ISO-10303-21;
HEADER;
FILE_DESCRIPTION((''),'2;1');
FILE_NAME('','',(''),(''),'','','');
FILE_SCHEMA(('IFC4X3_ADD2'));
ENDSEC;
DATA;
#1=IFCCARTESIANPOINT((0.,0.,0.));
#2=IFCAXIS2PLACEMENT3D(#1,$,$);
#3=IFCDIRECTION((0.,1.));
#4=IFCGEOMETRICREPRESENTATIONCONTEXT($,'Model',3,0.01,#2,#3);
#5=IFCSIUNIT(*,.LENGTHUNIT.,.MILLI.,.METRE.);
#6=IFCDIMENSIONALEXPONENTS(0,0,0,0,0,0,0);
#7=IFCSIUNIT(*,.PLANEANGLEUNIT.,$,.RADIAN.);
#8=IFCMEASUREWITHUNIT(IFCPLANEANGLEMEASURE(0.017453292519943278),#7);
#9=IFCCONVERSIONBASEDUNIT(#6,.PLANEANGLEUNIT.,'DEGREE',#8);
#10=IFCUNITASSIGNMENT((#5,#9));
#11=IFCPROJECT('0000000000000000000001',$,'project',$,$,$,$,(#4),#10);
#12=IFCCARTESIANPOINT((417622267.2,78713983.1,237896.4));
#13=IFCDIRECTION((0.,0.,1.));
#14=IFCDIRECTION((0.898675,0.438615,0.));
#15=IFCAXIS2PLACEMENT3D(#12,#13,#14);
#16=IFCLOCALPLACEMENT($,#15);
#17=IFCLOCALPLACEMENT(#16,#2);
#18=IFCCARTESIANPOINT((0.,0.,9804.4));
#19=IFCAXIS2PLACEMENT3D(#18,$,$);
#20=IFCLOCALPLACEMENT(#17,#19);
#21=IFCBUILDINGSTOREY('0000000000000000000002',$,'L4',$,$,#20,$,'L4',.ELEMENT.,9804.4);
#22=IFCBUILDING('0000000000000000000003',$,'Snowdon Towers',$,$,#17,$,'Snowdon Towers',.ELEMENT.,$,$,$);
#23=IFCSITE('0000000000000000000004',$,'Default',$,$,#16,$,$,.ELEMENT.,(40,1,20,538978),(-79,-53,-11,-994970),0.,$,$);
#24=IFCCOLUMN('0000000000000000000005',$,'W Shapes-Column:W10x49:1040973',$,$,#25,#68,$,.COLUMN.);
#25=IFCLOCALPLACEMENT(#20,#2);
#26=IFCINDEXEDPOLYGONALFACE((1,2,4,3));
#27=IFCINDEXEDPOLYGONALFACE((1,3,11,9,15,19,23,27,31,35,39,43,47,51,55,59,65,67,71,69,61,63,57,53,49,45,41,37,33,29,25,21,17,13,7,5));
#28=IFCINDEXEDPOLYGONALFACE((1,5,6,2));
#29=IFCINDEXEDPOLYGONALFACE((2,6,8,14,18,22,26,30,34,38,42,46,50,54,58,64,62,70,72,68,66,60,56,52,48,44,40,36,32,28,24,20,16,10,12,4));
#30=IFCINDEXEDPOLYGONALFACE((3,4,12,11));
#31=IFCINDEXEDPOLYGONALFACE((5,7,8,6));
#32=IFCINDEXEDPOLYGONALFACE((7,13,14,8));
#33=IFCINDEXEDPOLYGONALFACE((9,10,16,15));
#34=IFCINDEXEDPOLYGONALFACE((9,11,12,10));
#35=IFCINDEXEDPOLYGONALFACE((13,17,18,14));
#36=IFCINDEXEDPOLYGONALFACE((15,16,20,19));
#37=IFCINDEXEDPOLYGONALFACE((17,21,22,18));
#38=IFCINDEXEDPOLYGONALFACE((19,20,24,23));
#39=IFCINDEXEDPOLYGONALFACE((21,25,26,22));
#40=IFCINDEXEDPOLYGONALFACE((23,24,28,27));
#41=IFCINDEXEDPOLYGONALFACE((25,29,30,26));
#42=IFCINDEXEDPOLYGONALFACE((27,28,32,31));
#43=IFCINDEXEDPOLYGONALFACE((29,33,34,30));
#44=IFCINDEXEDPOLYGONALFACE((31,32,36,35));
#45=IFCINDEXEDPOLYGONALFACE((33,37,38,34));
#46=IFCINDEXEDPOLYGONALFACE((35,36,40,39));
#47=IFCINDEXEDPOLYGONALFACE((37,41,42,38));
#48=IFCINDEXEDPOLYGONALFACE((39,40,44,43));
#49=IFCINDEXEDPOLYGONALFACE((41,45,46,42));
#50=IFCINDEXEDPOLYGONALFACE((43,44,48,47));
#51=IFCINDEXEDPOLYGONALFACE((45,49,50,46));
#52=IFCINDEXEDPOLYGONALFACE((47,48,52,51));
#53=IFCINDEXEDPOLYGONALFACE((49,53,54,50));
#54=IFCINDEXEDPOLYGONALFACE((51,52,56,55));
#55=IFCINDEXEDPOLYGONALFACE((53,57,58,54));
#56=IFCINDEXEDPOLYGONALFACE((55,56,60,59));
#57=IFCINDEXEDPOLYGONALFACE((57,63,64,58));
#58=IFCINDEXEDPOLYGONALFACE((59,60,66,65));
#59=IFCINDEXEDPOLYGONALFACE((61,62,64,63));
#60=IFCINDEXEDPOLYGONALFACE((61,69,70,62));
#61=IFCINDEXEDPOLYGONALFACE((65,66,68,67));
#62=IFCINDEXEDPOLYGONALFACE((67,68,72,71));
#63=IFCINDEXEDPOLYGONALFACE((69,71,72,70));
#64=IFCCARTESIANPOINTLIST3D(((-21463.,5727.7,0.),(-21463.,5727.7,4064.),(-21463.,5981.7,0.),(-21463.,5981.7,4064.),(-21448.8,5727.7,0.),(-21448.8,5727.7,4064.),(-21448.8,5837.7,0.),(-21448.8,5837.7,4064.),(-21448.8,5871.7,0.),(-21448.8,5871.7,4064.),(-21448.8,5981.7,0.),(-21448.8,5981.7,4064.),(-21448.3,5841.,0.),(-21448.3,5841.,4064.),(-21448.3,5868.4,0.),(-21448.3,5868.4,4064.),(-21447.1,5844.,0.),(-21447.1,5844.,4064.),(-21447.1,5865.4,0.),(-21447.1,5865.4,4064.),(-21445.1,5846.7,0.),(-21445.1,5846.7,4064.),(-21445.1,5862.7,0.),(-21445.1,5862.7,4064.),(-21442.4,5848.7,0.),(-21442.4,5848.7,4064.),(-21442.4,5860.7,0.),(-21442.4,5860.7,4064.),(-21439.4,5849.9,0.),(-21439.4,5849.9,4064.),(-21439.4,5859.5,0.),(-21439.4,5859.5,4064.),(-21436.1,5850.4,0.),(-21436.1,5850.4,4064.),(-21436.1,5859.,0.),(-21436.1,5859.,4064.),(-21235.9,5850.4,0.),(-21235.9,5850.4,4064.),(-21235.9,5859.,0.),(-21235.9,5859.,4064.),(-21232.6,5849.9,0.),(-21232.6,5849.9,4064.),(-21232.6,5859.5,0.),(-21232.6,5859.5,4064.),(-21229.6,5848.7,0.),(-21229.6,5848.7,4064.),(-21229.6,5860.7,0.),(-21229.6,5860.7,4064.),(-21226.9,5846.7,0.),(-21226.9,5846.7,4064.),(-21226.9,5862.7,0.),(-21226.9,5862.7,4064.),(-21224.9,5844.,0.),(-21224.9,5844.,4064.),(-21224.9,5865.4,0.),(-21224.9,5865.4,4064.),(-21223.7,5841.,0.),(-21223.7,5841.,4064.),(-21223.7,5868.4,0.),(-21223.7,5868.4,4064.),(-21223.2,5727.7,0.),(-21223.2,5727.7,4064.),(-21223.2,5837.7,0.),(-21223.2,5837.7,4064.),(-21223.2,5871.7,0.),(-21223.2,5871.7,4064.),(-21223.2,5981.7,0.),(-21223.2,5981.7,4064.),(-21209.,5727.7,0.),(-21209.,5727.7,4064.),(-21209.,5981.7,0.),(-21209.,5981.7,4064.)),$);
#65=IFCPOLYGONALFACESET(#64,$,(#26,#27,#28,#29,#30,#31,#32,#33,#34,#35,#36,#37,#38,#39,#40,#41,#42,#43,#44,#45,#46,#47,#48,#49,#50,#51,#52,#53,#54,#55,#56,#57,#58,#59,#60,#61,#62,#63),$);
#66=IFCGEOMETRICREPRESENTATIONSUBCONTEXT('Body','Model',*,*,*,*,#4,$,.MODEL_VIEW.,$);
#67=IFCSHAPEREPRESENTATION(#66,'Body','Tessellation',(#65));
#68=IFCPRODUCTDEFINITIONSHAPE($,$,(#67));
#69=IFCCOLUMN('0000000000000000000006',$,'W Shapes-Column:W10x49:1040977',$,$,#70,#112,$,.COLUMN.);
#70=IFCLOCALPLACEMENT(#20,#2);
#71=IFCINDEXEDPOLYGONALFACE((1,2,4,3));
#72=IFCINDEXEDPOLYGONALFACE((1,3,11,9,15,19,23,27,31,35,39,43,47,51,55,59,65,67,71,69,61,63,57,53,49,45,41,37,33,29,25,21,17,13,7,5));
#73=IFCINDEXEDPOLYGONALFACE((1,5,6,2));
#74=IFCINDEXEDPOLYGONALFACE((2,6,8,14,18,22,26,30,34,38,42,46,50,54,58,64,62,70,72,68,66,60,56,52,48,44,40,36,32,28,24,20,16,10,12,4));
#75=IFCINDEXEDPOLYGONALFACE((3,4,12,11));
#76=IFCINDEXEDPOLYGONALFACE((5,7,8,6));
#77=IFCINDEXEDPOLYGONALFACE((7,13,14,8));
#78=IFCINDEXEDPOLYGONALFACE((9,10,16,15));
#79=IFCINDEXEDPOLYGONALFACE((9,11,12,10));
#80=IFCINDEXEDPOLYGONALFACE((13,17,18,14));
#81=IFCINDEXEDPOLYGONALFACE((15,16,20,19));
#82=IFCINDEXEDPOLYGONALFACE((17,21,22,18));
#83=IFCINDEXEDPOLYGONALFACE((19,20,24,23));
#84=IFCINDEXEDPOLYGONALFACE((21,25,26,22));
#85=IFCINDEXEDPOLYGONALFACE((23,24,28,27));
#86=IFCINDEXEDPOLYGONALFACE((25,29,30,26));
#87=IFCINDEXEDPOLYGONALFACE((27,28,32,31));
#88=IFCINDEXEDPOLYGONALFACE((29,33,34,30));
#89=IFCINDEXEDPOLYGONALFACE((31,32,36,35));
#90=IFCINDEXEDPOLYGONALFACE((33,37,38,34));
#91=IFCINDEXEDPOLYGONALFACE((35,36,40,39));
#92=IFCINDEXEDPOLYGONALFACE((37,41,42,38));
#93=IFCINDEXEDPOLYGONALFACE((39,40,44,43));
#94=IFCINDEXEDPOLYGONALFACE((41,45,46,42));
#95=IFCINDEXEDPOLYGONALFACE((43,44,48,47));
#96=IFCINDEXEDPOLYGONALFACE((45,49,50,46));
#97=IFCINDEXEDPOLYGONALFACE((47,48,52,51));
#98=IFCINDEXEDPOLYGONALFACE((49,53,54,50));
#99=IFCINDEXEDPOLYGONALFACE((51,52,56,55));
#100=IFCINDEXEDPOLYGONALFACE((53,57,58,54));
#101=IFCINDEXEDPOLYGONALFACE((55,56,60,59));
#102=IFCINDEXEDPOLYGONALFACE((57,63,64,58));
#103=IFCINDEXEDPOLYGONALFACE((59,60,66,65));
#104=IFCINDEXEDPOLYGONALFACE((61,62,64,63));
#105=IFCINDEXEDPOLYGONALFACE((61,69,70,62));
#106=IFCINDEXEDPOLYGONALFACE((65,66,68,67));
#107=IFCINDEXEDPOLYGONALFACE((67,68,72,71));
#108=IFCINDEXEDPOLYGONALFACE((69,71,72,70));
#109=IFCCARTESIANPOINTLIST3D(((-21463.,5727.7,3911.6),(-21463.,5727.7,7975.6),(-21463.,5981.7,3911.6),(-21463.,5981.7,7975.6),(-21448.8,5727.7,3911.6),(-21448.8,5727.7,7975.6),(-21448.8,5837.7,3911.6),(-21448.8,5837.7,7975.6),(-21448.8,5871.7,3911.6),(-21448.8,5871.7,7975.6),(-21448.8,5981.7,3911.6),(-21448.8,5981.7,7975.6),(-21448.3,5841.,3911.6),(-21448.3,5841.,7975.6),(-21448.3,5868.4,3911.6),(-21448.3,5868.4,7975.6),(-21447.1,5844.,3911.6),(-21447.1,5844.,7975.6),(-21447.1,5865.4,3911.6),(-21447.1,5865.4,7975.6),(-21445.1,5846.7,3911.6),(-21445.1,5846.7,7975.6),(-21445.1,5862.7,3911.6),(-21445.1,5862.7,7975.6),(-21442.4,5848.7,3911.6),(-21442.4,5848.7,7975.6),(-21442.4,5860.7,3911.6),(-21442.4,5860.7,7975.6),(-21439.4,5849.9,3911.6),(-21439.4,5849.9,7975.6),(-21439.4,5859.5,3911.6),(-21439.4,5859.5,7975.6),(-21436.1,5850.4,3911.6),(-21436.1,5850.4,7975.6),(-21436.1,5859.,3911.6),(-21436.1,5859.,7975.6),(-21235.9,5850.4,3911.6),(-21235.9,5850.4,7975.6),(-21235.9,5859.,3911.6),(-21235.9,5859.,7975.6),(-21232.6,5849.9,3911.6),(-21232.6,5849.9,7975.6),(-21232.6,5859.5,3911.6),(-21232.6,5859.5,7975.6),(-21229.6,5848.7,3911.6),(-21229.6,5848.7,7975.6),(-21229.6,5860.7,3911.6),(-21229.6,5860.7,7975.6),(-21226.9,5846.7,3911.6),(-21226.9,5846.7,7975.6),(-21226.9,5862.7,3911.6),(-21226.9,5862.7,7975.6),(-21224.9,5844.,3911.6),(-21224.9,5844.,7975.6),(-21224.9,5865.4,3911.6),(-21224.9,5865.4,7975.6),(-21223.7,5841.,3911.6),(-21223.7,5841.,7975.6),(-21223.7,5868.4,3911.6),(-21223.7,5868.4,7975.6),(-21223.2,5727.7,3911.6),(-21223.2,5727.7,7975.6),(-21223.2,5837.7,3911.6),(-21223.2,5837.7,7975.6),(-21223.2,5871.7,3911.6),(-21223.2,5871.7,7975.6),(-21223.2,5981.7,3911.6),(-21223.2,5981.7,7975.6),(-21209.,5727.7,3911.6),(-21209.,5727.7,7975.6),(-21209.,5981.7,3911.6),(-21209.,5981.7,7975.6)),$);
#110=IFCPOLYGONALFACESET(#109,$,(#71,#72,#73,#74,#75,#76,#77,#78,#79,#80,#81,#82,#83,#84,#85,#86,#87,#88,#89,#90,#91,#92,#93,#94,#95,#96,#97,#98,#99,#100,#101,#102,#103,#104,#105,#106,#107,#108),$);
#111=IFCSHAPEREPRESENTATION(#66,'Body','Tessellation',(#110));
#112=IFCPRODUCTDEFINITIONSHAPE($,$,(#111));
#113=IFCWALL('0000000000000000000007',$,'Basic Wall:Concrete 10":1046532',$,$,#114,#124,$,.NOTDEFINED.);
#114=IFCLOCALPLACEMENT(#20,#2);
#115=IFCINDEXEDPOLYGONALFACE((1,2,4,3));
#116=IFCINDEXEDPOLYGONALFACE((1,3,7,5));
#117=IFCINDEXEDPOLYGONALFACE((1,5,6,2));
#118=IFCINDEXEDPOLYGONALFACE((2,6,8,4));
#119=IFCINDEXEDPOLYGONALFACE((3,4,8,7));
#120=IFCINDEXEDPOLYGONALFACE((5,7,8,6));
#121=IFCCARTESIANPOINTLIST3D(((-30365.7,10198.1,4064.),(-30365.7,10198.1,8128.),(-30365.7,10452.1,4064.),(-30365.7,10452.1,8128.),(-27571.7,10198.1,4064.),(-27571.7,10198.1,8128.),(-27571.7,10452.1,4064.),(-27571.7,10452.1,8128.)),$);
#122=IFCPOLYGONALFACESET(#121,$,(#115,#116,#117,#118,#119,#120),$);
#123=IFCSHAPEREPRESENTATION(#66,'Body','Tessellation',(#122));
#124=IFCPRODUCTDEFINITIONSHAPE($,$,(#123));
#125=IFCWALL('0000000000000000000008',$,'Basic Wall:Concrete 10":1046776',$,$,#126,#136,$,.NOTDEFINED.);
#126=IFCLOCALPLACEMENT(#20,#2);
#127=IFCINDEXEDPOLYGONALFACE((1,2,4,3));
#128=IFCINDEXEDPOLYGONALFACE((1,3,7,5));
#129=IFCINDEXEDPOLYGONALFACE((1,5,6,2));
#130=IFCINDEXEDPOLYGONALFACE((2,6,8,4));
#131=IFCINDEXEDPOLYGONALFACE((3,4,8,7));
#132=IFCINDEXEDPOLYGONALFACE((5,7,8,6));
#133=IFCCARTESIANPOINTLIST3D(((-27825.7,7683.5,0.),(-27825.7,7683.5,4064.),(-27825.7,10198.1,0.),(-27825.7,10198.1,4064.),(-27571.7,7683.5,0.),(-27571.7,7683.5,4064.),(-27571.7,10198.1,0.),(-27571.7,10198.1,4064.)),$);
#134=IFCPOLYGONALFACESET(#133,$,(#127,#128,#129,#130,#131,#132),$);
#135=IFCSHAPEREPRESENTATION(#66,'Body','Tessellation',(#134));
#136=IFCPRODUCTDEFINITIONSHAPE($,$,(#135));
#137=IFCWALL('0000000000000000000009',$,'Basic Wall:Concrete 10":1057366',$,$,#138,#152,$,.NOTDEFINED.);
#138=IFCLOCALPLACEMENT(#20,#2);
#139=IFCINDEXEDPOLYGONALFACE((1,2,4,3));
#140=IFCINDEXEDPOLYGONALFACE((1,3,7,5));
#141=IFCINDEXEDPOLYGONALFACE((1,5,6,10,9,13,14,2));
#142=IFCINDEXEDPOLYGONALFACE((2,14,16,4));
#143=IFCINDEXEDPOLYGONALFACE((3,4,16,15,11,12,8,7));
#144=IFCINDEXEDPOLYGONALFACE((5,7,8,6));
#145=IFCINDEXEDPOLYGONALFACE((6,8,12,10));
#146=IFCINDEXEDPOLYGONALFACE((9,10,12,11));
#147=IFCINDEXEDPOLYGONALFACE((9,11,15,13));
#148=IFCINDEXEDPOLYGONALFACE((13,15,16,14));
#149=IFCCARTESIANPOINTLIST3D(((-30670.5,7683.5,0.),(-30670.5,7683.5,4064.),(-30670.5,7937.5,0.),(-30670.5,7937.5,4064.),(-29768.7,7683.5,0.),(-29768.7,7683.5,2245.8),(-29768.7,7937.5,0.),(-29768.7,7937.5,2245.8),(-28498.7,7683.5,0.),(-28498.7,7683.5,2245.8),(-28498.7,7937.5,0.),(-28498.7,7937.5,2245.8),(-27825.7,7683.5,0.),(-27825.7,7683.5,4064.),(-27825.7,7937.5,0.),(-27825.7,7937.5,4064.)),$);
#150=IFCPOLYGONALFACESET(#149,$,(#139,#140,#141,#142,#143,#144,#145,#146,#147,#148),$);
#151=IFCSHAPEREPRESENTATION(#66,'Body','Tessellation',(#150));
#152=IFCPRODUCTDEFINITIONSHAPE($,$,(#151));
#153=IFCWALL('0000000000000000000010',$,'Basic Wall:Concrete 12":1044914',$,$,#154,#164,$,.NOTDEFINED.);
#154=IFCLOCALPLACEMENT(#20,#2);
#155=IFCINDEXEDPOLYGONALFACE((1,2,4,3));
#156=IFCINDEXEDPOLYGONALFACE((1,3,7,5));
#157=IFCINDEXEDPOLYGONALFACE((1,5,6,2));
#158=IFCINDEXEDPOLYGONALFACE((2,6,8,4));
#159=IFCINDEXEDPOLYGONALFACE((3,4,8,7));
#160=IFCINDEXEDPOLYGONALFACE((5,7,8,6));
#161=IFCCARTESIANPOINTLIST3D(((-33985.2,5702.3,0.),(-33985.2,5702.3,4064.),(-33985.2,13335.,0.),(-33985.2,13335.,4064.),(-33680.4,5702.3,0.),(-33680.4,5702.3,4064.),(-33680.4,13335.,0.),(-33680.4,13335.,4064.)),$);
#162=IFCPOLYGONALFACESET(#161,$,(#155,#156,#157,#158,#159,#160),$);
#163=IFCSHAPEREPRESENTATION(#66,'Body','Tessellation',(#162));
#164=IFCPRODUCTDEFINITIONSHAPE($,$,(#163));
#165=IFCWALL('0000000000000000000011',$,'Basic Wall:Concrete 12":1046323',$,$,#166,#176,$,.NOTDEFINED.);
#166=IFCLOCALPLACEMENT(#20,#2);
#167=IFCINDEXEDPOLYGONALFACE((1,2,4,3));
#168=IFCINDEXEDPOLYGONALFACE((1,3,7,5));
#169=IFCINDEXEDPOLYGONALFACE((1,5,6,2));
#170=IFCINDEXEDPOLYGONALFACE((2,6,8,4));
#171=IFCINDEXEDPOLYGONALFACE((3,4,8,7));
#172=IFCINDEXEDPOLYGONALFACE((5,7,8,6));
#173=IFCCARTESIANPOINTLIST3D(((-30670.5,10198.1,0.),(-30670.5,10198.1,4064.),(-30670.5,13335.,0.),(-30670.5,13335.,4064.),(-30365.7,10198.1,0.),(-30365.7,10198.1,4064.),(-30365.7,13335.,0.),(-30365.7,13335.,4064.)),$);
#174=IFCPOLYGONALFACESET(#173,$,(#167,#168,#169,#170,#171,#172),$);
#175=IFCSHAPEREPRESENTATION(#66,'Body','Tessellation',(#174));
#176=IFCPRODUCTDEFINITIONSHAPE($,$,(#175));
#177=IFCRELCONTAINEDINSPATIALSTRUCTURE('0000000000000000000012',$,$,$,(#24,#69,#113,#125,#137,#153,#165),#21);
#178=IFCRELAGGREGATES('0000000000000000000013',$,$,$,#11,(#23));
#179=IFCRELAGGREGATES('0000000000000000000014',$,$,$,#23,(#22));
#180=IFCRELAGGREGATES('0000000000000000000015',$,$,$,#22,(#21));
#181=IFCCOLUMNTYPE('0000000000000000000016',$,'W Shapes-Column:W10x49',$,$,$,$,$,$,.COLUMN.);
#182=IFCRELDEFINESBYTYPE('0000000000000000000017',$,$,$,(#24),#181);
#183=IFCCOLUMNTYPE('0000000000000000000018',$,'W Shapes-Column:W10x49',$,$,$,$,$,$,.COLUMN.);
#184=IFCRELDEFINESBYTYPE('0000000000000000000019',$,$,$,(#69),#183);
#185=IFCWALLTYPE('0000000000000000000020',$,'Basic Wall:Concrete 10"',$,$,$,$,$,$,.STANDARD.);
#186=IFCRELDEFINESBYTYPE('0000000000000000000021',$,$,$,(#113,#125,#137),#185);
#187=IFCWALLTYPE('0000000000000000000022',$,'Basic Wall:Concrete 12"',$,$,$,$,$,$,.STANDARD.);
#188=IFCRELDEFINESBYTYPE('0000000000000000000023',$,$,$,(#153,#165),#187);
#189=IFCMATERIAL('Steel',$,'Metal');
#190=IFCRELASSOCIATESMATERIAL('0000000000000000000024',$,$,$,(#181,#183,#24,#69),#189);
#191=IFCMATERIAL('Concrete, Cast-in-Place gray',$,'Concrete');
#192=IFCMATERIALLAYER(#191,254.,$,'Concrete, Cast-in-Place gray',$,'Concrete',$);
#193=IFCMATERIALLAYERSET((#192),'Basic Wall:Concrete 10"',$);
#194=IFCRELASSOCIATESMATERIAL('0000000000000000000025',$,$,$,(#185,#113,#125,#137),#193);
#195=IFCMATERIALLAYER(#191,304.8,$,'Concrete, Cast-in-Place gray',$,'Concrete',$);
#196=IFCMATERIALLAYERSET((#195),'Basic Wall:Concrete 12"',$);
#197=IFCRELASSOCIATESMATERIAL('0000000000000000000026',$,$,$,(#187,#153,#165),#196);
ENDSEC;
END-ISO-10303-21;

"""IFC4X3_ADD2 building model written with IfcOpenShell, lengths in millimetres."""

from ifc_helpers import new_model, entity, si_unit, converted_unit, direction, frame, frame_2d, origin, place, context, subcontext, project, spatial, rectangle, i_section, extrude, source, transform, mapped, material, layer, layer_set, material_profile, profile_set, profile_usage, type_object, type_shapes, element, save


model = new_model("IFC4X3_ADD2")

# Units and contexts
model_context = context("Model", 3, precision=0.01, world=origin(), true_north=direction((0.0, 1.0)))
body_context = subcontext(model_context, "Body", "Model", "MODEL_VIEW")
ifc_project = project(units=[si_unit("LENGTHUNIT", "METRE", prefix="MILLI"), converted_unit("PLANEANGLEUNIT", "DEGREE", entity("IfcPlaneAngleMeasure", 0.017453292519943278), si_unit("PLANEANGLEUNIT", "RADIAN"), dimensions=[0, 0, 0, 0, 0, 0, 0])], contexts=[model_context])

# Site, building, storey
site_placement = place(None, frame((417622267.2, 78713983.1, 237896.4), z_axis=(0.0, 0.0, 1.0), x_axis=(0.898675, 0.438615, 0.0)))
site = spatial("IfcSite", under=ifc_project, at=site_placement, Name="Default", CompositionType="ELEMENT", RefLatitude=(40, 1, 20, 538978), RefLongitude=(-79, -53, -11, -994970), RefElevation=0.0)
building_placement = place(site_placement, origin())
building = spatial("IfcBuilding", under=site, at=building_placement, Name="Snowdon Towers", LongName="Snowdon Towers", CompositionType="ELEMENT")
storey_placement = place(building_placement, frame((0.0, 0.0, 9804.4)))
storey = spatial("IfcBuildingStorey", under=building, at=storey_placement, Name="L4", LongName="L4", CompositionType="ELEMENT", Elevation=9804.4)

# Columns
ifc_material_1 = material(Name="Steel", Category="Metal")
ifc_material_profile_1 = material_profile(ifc_material_1, i_section(OverallWidth=254.0, OverallDepth=254.0, WebThickness=8.6, FlangeThickness=14.2, FilletRadius=12.7, at=frame_2d((0.0, 0.0), x_axis=(1.0, 0.0))), Name="W10x49")
ifc_profile_set_1 = profile_set([ifc_material_profile_1], Name="W10x49")
ifc_profile_usage_1 = profile_usage(ifc_profile_set_1)
column_type_1 = type_object("IfcColumnType", Name="W Shapes-Column:W10x49", PredefinedType="COLUMN", material=ifc_profile_set_1)
shared_shape_1 = source(origin(), body_context, "Body", "SweptSolid", [
    extrude(i_section(OverallWidth=254.0, OverallDepth=254.0, WebThickness=8.6, FlangeThickness=14.2, FilletRadius=12.7, at=frame_2d((0.0, 0.0), x_axis=(1.0, 0.0))), frame((0.0, 0.0, 9804.4), z_axis=(0.0, 0.0, 1.0), x_axis=(-1.0, 0.0, 0.0)), (0.0, 0.0, 1.0), 4064.0),
])
type_shapes(column_type_1, [shared_shape_1])
column_1_placement = place(storey_placement, frame((-21336.0, 5854.7, -9804.4), z_axis=(0.0, 0.0, 1.0), x_axis=(0.0, 1.0, 0.0)))
element("IfcColumn", 1, at=column_1_placement, inside=storey, type_object=column_type_1, material=ifc_profile_usage_1, Name="W Shapes-Column:W10x49:1040973", PredefinedType="COLUMN", context=body_context, shape_type="MappedRepresentation", body=[
    mapped(shared_shape_1, transform((0.0, 0.0, 0.0), scale=1.0)),
])
column_type_2 = type_object("IfcColumnType", Name="W Shapes-Column:W10x49", PredefinedType="COLUMN", material=ifc_profile_set_1)
shared_shape_2 = source(origin(), body_context, "Body", "SweptSolid", [
    extrude(i_section(OverallWidth=254.0, OverallDepth=254.0, WebThickness=8.6, FlangeThickness=14.2, FilletRadius=12.7, at=frame_2d((0.0, 0.0), x_axis=(1.0, 0.0))), frame((0.0, 0.0, 13716.0), z_axis=(0.0, 0.0, 1.0), x_axis=(-1.0, 0.0, 0.0)), (0.0, 0.0, 1.0), 4064.0),
])
type_shapes(column_type_2, [shared_shape_2])
column_2_placement = place(storey_placement, frame((-21336.0, 5854.7, -9804.4), z_axis=(0.0, 0.0, 1.0), x_axis=(0.0, 1.0, 0.0)))
element("IfcColumn", 2, at=column_2_placement, inside=storey, type_object=column_type_2, material=ifc_profile_usage_1, Name="W Shapes-Column:W10x49:1040977", PredefinedType="COLUMN", context=body_context, shape_type="MappedRepresentation", body=[
    mapped(shared_shape_2, transform((0.0, 0.0, 0.0), scale=1.0)),
])

# Walls
ifc_material_2 = material(Name="Concrete, Cast-in-Place gray", Category="Concrete")
ifc_layer_1 = layer(ifc_material_2, 254.0, Name="Concrete, Cast-in-Place gray", Category="Concrete")
ifc_layer_set_1 = layer_set([ifc_layer_1], Name="Basic Wall:Concrete 10\"")
wall_type_1 = type_object("IfcWallType", Name="Basic Wall:Concrete 10\"", PredefinedType="STANDARD", material=ifc_layer_set_1)
wall_1_placement = place(storey_placement, frame((-30365.7, 10325.1, 4064.0)))
element("IfcWall", 3, at=wall_1_placement, inside=storey, type_object=wall_type_1, material=ifc_layer_set_1, Name="Basic Wall:Concrete 10\":1046532", PredefinedType="NOTDEFINED", context=body_context, shape_type="SweptSolid", body=[
    extrude(rectangle(XDim=2794.0, YDim=254.0, at=frame_2d((1397.0, 0.0), x_axis=(-1.0, 0.0))), origin(), (0.0, 0.0, 1.0), 4064.0),
])
wall_2_placement = place(storey_placement, frame((-27698.7, 10198.1, 0.0), z_axis=(0.0, 0.0, 1.0), x_axis=(0.0, -1.0, 0.0)))
element("IfcWall", 4, at=wall_2_placement, inside=storey, type_object=wall_type_1, material=ifc_layer_set_1, Name="Basic Wall:Concrete 10\":1046776", PredefinedType="NOTDEFINED", context=body_context, shape_type="SweptSolid", body=[
    extrude(rectangle(XDim=2514.6, YDim=254.0, at=frame_2d((1257.3, 0.0), x_axis=(-1.0, 0.0))), origin(), (0.0, 0.0, 1.0), 4064.0),
])

# Wall, opening
wall_3_placement = place(storey_placement, frame((-27825.7, 7810.5, 0.0), z_axis=(0.0, 0.0, 1.0), x_axis=(-1.0, 0.0, 0.0)))
wall_3 = element("IfcWall", 5, at=wall_3_placement, inside=storey, type_object=wall_type_1, material=ifc_layer_set_1, Name="Basic Wall:Concrete 10\":1057366", PredefinedType="NOTDEFINED", context=body_context, shape_type="SweptSolid", body=[
    extrude(rectangle(XDim=2844.8, YDim=254.0, at=frame_2d((1422.4, 0.0), x_axis=(-1.0, 0.0))), origin(), (0.0, 0.0, 1.0), 4064.0),
])
opening_1_placement = place(wall_3_placement, origin())
element("IfcOpeningElement", 6, at=opening_1_placement, cuts=wall_3, PredefinedType="OPENING", context=body_context, shape_type="SweptSolid", body=[
    extrude(rectangle(XDim=2245.8, YDim=1270.0, at=frame_2d((0.0, 0.0), x_axis=(0.0, 1.0))), frame((1308.0, 127.0, 1122.9), z_axis=(0.0, -1.0, 0.0), x_axis=(1.0, 0.0, 0.0)), (0.0, 0.0, 1.0), 254.0),
])

# Walls
ifc_layer_2 = layer(ifc_material_2, 304.8, Name="Concrete, Cast-in-Place gray", Category="Concrete")
ifc_layer_set_2 = layer_set([ifc_layer_2], Name="Basic Wall:Concrete 12\"")
wall_type_2 = type_object("IfcWallType", Name="Basic Wall:Concrete 12\"", PredefinedType="STANDARD", material=ifc_layer_set_2)
wall_4_placement = place(storey_placement, frame((-33832.8, 13335.0, 0.0), z_axis=(0.0, 0.0, 1.0), x_axis=(0.0, -1.0, 0.0)))
element("IfcWall", 7, at=wall_4_placement, inside=storey, type_object=wall_type_2, material=ifc_layer_set_2, Name="Basic Wall:Concrete 12\":1044914", PredefinedType="NOTDEFINED", context=body_context, shape_type="SweptSolid", body=[
    extrude(rectangle(XDim=7632.7, YDim=304.8, at=frame_2d((3816.4, 0.0), x_axis=(-1.0, 0.0))), origin(), (0.0, 0.0, 1.0), 4064.0),
])
wall_5_placement = place(storey_placement, frame((-30518.1, 10198.1, 0.0), z_axis=(0.0, 0.0, 1.0), x_axis=(0.0, 1.0, 0.0)))
element("IfcWall", 8, at=wall_5_placement, inside=storey, type_object=wall_type_2, material=ifc_layer_set_2, Name="Basic Wall:Concrete 12\":1046323", PredefinedType="NOTDEFINED", context=body_context, shape_type="SweptSolid", body=[
    extrude(rectangle(XDim=3136.9, YDim=304.8, at=frame_2d((1568.5, 0.0), x_axis=(-1.0, 0.0))), origin(), (0.0, 0.0, 1.0), 4064.0),
])

save(model, "model.ifc")
